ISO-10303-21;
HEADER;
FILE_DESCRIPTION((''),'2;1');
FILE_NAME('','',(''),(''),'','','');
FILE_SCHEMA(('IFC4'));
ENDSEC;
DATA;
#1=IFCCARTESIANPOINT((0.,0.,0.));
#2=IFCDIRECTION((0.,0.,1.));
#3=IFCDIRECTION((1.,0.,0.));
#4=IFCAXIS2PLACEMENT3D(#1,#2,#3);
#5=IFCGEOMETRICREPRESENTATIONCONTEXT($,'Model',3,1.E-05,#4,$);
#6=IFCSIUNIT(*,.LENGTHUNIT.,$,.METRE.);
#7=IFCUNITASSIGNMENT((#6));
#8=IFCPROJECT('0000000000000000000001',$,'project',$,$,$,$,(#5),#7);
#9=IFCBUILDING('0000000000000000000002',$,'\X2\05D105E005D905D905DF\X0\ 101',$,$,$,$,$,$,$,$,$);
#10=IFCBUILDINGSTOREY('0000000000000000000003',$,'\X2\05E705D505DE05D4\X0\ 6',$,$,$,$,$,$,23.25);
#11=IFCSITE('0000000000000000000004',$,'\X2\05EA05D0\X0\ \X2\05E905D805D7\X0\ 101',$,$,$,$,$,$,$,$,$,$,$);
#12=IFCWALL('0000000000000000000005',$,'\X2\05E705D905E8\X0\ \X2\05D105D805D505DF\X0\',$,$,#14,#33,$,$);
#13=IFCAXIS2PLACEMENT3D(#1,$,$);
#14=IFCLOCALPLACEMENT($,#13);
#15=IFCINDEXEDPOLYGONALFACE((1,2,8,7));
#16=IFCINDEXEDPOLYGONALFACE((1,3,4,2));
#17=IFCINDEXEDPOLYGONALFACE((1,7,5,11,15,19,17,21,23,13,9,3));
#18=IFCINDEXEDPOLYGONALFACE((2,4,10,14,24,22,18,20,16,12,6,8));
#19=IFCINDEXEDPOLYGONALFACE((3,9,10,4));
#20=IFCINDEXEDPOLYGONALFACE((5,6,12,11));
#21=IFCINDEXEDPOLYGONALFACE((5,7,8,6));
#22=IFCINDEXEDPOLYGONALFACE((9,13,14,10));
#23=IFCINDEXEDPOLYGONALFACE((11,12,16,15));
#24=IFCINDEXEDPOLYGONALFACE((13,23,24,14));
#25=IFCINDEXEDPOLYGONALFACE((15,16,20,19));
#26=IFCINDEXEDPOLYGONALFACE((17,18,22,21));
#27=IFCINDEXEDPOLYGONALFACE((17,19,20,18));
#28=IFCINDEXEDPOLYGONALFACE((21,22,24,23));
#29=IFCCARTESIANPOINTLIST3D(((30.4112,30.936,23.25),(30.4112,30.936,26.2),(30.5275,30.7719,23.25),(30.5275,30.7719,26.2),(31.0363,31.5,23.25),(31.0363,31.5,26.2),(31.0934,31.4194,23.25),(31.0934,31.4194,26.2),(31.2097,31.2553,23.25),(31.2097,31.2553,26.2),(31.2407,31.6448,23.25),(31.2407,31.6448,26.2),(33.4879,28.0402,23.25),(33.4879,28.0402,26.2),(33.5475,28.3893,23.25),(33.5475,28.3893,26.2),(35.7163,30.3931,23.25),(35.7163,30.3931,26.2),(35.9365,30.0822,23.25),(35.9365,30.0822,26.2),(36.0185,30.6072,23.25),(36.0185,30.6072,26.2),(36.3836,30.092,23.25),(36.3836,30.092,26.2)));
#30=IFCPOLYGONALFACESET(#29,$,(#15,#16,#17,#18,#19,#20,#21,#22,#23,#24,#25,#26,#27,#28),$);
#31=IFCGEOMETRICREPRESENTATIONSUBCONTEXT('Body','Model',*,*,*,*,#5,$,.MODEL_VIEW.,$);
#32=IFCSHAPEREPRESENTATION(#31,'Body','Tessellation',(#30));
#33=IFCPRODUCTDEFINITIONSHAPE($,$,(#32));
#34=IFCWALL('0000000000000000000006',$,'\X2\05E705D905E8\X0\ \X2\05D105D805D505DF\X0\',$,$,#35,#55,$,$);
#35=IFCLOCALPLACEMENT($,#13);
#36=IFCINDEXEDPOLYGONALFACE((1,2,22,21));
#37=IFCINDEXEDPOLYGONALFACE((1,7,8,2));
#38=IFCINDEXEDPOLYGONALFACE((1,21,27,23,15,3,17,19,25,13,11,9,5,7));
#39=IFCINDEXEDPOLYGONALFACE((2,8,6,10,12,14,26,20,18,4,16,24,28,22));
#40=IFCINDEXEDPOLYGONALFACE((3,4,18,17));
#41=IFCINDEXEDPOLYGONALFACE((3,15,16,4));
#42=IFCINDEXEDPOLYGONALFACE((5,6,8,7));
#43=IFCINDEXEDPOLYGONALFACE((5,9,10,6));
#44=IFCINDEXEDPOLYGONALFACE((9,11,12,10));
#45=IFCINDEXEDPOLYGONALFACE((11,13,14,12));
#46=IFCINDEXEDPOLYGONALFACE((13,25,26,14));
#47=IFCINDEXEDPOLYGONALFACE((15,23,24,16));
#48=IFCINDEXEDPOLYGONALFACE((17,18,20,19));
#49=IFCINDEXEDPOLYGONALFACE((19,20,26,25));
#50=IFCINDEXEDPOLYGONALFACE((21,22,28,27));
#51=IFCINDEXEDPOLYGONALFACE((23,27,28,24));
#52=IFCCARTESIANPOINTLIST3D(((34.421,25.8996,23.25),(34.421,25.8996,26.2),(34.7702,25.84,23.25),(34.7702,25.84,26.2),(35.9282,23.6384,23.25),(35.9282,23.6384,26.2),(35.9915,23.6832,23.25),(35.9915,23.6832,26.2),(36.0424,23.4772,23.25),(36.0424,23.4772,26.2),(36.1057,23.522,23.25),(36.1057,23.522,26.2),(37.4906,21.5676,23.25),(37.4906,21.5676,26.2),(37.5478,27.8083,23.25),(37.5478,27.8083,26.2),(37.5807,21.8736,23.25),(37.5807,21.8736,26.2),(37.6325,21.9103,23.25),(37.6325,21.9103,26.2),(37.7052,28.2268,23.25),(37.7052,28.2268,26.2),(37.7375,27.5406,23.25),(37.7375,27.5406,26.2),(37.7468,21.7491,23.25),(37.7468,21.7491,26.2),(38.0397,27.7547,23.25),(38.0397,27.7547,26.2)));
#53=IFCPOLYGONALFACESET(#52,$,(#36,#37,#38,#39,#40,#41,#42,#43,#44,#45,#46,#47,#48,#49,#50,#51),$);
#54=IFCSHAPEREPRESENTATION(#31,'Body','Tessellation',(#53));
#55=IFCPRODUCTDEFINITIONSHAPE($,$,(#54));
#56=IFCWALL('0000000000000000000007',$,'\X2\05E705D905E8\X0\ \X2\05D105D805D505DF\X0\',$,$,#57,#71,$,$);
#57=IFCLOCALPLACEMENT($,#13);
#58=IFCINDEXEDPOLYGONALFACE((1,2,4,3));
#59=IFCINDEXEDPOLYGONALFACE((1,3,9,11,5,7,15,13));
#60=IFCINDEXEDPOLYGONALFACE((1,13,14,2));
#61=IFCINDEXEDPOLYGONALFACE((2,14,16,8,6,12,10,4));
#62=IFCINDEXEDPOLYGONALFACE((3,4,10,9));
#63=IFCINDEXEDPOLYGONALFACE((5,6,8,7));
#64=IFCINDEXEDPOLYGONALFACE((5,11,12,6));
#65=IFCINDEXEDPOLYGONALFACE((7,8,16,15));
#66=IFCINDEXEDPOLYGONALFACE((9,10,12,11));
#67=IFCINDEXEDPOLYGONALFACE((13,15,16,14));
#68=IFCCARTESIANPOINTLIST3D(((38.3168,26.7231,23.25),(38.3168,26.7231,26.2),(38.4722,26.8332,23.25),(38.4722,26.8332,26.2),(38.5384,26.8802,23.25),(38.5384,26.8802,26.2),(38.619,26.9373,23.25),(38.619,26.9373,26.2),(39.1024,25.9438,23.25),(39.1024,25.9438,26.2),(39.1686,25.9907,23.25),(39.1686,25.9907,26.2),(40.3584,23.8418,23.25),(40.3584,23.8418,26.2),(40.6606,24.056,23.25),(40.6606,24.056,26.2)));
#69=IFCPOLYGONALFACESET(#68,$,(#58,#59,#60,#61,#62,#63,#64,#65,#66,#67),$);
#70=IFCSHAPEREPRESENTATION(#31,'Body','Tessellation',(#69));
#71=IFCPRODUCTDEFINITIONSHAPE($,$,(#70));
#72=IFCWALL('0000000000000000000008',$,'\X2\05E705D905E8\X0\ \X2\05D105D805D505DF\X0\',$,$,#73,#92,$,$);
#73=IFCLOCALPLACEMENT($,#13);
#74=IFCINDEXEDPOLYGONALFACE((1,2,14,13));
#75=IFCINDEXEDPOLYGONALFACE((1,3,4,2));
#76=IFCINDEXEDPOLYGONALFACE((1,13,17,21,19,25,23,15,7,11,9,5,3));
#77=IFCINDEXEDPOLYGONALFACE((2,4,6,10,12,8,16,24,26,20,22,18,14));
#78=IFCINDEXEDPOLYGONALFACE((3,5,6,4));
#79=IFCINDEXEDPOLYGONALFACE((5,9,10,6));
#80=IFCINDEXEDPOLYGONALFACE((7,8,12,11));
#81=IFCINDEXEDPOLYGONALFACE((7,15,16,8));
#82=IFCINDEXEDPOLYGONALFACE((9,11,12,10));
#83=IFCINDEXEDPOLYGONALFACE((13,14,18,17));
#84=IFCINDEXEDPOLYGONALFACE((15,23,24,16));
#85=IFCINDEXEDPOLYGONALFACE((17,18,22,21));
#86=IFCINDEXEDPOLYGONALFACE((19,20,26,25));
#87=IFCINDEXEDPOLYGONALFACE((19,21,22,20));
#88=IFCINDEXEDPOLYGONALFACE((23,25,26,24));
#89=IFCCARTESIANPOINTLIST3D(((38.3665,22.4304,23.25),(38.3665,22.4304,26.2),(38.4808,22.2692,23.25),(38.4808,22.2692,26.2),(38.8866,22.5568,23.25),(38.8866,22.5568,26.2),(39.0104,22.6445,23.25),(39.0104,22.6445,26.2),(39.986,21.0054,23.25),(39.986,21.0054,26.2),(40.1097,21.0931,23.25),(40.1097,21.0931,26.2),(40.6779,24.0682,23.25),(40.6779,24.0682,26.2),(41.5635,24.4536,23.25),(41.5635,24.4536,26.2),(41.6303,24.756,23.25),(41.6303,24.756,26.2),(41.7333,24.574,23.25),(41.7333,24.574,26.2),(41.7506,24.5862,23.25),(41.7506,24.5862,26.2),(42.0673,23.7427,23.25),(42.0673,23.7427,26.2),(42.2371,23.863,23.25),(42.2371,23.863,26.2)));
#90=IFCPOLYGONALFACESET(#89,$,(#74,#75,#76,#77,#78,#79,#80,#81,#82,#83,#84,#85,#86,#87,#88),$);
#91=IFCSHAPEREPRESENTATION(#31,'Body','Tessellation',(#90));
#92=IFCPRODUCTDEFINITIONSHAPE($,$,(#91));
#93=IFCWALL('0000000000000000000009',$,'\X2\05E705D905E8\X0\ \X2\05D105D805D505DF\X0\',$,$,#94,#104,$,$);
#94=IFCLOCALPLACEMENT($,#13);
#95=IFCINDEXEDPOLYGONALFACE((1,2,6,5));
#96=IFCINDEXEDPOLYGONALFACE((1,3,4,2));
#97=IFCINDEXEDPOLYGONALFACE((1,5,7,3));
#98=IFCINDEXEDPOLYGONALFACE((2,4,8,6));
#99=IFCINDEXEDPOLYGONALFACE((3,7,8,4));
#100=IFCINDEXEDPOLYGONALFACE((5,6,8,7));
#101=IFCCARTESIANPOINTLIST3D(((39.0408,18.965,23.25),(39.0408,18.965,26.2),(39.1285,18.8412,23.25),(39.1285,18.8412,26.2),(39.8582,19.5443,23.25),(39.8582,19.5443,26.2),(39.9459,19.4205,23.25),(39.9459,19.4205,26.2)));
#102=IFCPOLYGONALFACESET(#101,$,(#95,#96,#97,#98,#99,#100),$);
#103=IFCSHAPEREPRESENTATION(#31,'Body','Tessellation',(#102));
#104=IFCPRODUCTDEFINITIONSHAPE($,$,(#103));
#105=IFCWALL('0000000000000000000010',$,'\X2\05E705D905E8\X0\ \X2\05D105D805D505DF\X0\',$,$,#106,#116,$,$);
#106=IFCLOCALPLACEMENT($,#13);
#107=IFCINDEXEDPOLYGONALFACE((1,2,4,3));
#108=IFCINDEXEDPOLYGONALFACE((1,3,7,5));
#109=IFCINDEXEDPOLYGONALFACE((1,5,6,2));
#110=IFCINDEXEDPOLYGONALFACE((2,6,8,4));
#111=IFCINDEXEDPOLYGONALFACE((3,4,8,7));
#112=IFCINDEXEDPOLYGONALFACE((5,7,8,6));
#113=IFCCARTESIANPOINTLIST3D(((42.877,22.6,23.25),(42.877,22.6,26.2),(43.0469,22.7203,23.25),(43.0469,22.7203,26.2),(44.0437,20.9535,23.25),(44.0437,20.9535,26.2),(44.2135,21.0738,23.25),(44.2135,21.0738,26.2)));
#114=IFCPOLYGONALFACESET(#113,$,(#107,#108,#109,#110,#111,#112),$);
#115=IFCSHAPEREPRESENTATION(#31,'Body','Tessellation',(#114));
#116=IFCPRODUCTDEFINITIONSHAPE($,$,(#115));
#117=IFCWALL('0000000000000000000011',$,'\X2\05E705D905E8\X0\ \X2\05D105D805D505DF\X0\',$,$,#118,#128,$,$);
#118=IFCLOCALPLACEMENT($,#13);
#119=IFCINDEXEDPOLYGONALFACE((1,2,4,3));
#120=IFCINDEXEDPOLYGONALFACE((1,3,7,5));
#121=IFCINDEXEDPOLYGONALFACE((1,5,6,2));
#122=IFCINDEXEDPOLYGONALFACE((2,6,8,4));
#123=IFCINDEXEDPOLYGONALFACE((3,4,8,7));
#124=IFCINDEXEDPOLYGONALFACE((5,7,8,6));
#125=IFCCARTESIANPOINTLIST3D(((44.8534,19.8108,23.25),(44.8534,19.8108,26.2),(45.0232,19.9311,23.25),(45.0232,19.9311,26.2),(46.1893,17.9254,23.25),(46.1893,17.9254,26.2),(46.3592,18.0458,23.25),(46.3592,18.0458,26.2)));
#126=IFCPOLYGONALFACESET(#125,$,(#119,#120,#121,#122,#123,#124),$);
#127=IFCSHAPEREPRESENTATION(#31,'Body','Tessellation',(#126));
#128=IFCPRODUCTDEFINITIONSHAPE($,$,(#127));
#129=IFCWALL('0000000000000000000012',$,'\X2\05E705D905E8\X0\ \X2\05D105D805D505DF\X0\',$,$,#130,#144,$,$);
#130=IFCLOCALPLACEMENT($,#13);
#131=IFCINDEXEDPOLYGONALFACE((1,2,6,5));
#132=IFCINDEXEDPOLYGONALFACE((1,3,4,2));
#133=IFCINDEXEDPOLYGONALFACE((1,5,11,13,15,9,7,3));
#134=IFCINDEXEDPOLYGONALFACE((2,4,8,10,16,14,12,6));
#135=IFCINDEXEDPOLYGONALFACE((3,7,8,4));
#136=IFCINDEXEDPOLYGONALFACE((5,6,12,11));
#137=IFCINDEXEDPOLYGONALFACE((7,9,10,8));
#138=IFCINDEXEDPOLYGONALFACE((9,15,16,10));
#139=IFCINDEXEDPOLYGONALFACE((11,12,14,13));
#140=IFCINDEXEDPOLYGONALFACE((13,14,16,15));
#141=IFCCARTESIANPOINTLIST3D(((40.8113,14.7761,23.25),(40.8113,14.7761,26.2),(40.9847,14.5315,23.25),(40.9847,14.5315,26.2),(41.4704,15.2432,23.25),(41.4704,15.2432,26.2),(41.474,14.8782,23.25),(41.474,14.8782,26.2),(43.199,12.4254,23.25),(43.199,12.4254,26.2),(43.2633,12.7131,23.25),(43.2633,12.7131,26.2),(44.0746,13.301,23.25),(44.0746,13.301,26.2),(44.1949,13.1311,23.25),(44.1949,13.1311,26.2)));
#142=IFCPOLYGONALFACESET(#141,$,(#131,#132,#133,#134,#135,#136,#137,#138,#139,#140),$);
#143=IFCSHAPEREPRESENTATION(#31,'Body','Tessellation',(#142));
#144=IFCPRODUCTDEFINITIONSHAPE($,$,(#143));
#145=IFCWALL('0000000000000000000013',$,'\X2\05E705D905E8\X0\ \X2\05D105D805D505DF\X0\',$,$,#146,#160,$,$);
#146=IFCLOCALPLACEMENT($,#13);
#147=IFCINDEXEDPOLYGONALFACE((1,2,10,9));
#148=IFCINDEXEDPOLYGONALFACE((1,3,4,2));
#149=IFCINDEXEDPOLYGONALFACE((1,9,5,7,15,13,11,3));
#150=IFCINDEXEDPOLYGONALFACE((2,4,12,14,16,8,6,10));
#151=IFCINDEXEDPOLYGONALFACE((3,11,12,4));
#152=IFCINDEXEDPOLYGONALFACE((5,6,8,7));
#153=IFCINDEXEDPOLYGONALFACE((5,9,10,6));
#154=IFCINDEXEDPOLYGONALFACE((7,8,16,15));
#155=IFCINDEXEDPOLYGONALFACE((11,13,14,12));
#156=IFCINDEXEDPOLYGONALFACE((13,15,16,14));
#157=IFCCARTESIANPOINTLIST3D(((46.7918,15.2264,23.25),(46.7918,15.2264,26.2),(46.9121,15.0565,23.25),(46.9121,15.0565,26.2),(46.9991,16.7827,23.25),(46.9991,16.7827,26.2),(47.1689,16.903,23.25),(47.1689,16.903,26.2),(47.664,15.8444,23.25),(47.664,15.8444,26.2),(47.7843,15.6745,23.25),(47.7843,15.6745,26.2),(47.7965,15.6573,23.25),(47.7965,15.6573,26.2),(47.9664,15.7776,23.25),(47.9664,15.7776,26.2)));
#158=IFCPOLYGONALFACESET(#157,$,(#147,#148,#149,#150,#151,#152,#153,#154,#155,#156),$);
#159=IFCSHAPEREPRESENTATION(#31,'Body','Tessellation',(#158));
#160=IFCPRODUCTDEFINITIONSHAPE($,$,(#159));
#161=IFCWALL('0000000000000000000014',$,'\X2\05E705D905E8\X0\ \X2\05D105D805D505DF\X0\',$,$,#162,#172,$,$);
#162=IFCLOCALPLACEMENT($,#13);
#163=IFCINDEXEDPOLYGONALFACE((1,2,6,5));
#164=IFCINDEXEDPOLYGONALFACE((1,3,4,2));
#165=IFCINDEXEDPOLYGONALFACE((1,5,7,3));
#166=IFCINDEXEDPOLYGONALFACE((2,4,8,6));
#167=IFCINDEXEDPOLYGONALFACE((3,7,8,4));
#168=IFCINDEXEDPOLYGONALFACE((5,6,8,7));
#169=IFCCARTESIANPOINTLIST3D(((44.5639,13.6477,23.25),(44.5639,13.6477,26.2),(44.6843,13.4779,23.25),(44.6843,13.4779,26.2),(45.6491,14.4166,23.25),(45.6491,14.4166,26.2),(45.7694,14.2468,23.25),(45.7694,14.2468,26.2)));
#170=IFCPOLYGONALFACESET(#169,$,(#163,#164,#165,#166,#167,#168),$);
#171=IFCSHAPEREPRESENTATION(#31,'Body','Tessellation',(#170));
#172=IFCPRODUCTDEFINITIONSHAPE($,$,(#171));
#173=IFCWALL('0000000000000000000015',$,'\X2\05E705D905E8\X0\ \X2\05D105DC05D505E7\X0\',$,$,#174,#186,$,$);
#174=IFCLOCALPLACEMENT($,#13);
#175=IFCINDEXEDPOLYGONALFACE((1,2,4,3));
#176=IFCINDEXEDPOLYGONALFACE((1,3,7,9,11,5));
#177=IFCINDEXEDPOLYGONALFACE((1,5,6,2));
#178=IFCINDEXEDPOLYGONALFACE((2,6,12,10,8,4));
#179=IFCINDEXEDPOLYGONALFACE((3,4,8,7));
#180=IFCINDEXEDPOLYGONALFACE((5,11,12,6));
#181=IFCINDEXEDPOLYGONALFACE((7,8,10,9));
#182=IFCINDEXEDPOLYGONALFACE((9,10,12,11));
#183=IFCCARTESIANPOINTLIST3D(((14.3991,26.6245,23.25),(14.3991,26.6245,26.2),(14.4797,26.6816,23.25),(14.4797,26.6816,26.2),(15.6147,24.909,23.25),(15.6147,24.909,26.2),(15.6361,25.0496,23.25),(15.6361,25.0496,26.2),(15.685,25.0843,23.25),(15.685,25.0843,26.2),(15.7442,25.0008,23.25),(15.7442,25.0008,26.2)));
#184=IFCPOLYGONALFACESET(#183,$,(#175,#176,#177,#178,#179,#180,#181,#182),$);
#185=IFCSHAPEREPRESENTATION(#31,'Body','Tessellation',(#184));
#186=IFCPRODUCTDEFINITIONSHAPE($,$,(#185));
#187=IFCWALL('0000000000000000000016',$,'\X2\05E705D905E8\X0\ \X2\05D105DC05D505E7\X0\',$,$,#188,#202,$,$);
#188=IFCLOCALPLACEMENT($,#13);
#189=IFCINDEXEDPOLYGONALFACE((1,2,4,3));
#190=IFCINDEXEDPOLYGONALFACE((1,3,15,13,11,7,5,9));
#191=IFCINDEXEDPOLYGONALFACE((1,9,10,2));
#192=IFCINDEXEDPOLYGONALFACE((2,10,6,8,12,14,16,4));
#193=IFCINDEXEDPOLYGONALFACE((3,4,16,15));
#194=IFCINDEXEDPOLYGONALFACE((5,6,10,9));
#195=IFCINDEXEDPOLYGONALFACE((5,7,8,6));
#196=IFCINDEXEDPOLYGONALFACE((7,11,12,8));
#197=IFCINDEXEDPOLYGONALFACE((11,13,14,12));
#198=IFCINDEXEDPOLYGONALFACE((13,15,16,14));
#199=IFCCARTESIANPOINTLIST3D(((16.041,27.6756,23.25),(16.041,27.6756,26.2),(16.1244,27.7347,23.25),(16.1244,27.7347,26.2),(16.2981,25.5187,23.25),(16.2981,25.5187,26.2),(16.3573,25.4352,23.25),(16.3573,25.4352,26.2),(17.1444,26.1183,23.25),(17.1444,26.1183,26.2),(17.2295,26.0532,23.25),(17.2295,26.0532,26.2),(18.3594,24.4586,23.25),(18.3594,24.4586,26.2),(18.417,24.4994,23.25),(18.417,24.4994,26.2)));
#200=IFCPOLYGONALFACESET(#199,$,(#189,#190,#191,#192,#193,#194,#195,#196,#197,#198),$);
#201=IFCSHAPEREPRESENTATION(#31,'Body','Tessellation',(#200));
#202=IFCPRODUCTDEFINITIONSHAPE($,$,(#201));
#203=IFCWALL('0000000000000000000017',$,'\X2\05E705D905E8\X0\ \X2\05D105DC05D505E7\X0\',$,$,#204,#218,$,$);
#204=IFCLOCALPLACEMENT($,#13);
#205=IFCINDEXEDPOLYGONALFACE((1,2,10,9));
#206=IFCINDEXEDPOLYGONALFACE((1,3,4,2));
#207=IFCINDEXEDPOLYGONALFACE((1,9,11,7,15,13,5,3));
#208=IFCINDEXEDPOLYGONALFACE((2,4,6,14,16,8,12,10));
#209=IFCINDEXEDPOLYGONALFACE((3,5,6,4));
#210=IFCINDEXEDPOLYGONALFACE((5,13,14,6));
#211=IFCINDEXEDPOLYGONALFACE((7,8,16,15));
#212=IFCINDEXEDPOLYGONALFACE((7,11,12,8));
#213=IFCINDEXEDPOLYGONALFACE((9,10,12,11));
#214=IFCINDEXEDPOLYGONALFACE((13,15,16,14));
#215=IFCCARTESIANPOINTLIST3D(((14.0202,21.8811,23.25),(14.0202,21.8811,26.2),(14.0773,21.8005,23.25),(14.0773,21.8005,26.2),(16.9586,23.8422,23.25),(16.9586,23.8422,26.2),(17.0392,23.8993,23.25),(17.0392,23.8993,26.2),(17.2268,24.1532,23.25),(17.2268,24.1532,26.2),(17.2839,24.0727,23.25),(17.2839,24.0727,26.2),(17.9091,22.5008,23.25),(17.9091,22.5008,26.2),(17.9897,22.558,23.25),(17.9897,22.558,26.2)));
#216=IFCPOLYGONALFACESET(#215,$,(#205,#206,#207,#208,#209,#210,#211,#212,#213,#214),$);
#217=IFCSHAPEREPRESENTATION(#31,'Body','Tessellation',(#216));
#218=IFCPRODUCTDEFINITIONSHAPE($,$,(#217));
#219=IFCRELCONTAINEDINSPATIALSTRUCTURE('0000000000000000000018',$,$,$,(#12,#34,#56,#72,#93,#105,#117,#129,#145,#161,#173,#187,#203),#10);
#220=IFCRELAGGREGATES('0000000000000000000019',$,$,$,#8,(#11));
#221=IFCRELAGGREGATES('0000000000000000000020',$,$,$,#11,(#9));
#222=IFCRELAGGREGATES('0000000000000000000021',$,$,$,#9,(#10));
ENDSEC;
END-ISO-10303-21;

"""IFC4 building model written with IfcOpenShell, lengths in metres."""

from ifc_helpers import new_model, si_unit, frame, origin_with_axes, context, subcontext, project, spatial, polyline, outline, extrude, element, save


model = new_model("IFC4")

# Units and contexts
model_context = context("Model", 3, precision=1e-05, world=origin_with_axes())
body_context = subcontext(model_context, "Body", "Model", "MODEL_VIEW")
ifc_project = project(units=[si_unit("LENGTHUNIT", "METRE")], contexts=[model_context])

# Site, building, storey
site = spatial("IfcSite", under=ifc_project, Name="תא שטח 101")
building = spatial("IfcBuilding", under=site, Name="בניין 101")
storey = spatial("IfcBuildingStorey", under=building, Name="קומה 6", Elevation=23.25)

# Walls
element("IfcWall", 1, inside=storey, Name="קיר בטון", context=body_context, shape_type="SweptSolid", body=[
    extrude(outline(polyline([(31.2097, 31.2553), (33.4879, 28.0402), (36.3836, 30.092), (36.0185, 30.6072), (35.7163, 30.3931), (35.9365, 30.0822), (33.5475, 28.3893), (31.2407, 31.6448), (31.0363, 31.5), (31.0934, 31.4194), (30.4112, 30.936), (30.5275, 30.7719), (31.2097, 31.2553)])), frame((0.0, 0.0, 23.25)), (0.0, 0.0, 1.0), 2.95),
])
element("IfcWall", 2, inside=storey, Name="קיר בטון", context=body_context, shape_type="SweptSolid", body=[
    extrude(outline(polyline([(34.421, 25.8996), (35.9915, 23.6832), (35.9282, 23.6384), (36.0424, 23.4772), (36.1057, 23.522), (37.4906, 21.5676), (37.7468, 21.7491), (37.6325, 21.9103), (37.5807, 21.8736), (34.7702, 25.84), (37.5478, 27.8083), (37.7375, 27.5406), (38.0397, 27.7547), (37.7052, 28.2268), (34.421, 25.8996)])), frame((0.0, 0.0, 23.25)), (0.0, 0.0, 1.0), 2.95),
])
element("IfcWall", 3, inside=storey, Name="קיר בטון", context=body_context, shape_type="SweptSolid", body=[
    extrude(outline(polyline([(38.3168, 26.7231), (40.3584, 23.8418), (40.6606, 24.056), (38.619, 26.9373), (38.5384, 26.8802), (39.1686, 25.9907), (39.1024, 25.9438), (38.4722, 26.8332), (38.3168, 26.7231)])), frame((0.0, 0.0, 23.25)), (0.0, 0.0, 1.0), 2.95),
])
element("IfcWall", 4, inside=storey, Name="קיר בטון", context=body_context, shape_type="SweptSolid", body=[
    extrude(outline(polyline([(38.3665, 22.4304), (38.4808, 22.2692), (38.8866, 22.5568), (39.986, 21.0054), (40.1097, 21.0931), (39.0104, 22.6445), (41.5635, 24.4536), (42.0673, 23.7427), (42.2371, 23.863), (41.7333, 24.574), (41.7506, 24.5862), (41.6303, 24.756), (40.6779, 24.0682), (38.3665, 22.4304)])), frame((0.0, 0.0, 23.25)), (0.0, 0.0, 1.0), 2.95),
])
element("IfcWall", 5, inside=storey, Name="קיר בטון", context=body_context, shape_type="SweptSolid", body=[
    extrude(outline(polyline([(39.9459, 19.4205), (39.8582, 19.5443), (39.0408, 18.965), (39.1285, 18.8412), (39.9459, 19.4205)])), frame((0.0, 0.0, 23.25)), (0.0, 0.0, 1.0), 2.95),
])
element("IfcWall", 6, inside=storey, Name="קיר בטון", context=body_context, shape_type="SweptSolid", body=[
    extrude(outline(polyline([(43.0469, 22.7203), (42.877, 22.6), (44.0437, 20.9535), (44.2135, 21.0738), (43.0469, 22.7203)])), frame((0.0, 0.0, 23.25)), (0.0, 0.0, 1.0), 2.95),
])
element("IfcWall", 7, inside=storey, Name="קיר בטון", context=body_context, shape_type="SweptSolid", body=[
    extrude(outline(polyline([(44.8534, 19.8108), (46.1893, 17.9254), (46.3592, 18.0458), (45.0232, 19.9311), (44.8534, 19.8108)])), frame((0.0, 0.0, 23.25)), (0.0, 0.0, 1.0), 2.95),
])
element("IfcWall", 8, inside=storey, Name="קיר בטון", context=body_context, shape_type="SweptSolid", body=[
    extrude(outline(polyline([(41.474, 14.8782), (43.199, 12.4254), (44.1949, 13.1311), (44.0746, 13.301), (43.2633, 12.7131), (41.4704, 15.2432), (40.8113, 14.7761), (40.9847, 14.5315), (41.474, 14.8782)])), frame((0.0, 0.0, 23.25)), (0.0, 0.0, 1.0), 2.95),
])
element("IfcWall", 9, inside=storey, Name="קיר בטון", context=body_context, shape_type="SweptSolid", body=[
    extrude(outline(polyline([(47.7843, 15.6745), (47.7965, 15.6573), (47.9664, 15.7776), (47.1689, 16.903), (46.9991, 16.7827), (47.664, 15.8444), (46.7918, 15.2264), (46.9121, 15.0565), (47.7843, 15.6745)])), frame((0.0, 0.0, 23.25)), (0.0, 0.0, 1.0), 2.95),
])
element("IfcWall", 10, inside=storey, Name="קיר בטון", context=body_context, shape_type="SweptSolid", body=[
    extrude(outline(polyline([(45.6491, 14.4166), (44.5639, 13.6477), (44.6843, 13.4779), (45.7694, 14.2468), (45.6491, 14.4166)])), frame((0.0, 0.0, 23.25)), (0.0, 0.0, 1.0), 2.95),
])
element("IfcWall", 11, inside=storey, Name="קיר בלוק", context=body_context, shape_type="SweptSolid", body=[
    extrude(outline(polyline([(14.3991, 26.6245), (15.6147, 24.909), (15.7442, 25.0008), (15.685, 25.0843), (15.6361, 25.0496), (14.4797, 26.6816), (14.3991, 26.6245)])), frame((0.0, 0.0, 23.25)), (0.0, 0.0, 1.0), 2.95),
])
element("IfcWall", 12, inside=storey, Name="קיר בלוק", context=body_context, shape_type="SweptSolid", body=[
    extrude(outline(polyline([(16.3573, 25.4352), (17.2295, 26.0532), (18.3594, 24.4586), (18.417, 24.4994), (16.1244, 27.7347), (16.041, 27.6756), (17.1444, 26.1183), (16.2981, 25.5187), (16.3573, 25.4352)])), frame((0.0, 0.0, 23.25)), (0.0, 0.0, 1.0), 2.95),
])
element("IfcWall", 13, inside=storey, Name="קיר בלוק", context=body_context, shape_type="SweptSolid", body=[
    extrude(outline(polyline([(17.2839, 24.0727), (17.2268, 24.1532), (14.0202, 21.8811), (14.0773, 21.8005), (16.9586, 23.8422), (17.9091, 22.5008), (17.9897, 22.558), (17.0392, 23.8993), (17.2839, 24.0727)])), frame((0.0, 0.0, 23.25)), (0.0, 0.0, 1.0), 2.95),
])

save(model, "model.ifc")
